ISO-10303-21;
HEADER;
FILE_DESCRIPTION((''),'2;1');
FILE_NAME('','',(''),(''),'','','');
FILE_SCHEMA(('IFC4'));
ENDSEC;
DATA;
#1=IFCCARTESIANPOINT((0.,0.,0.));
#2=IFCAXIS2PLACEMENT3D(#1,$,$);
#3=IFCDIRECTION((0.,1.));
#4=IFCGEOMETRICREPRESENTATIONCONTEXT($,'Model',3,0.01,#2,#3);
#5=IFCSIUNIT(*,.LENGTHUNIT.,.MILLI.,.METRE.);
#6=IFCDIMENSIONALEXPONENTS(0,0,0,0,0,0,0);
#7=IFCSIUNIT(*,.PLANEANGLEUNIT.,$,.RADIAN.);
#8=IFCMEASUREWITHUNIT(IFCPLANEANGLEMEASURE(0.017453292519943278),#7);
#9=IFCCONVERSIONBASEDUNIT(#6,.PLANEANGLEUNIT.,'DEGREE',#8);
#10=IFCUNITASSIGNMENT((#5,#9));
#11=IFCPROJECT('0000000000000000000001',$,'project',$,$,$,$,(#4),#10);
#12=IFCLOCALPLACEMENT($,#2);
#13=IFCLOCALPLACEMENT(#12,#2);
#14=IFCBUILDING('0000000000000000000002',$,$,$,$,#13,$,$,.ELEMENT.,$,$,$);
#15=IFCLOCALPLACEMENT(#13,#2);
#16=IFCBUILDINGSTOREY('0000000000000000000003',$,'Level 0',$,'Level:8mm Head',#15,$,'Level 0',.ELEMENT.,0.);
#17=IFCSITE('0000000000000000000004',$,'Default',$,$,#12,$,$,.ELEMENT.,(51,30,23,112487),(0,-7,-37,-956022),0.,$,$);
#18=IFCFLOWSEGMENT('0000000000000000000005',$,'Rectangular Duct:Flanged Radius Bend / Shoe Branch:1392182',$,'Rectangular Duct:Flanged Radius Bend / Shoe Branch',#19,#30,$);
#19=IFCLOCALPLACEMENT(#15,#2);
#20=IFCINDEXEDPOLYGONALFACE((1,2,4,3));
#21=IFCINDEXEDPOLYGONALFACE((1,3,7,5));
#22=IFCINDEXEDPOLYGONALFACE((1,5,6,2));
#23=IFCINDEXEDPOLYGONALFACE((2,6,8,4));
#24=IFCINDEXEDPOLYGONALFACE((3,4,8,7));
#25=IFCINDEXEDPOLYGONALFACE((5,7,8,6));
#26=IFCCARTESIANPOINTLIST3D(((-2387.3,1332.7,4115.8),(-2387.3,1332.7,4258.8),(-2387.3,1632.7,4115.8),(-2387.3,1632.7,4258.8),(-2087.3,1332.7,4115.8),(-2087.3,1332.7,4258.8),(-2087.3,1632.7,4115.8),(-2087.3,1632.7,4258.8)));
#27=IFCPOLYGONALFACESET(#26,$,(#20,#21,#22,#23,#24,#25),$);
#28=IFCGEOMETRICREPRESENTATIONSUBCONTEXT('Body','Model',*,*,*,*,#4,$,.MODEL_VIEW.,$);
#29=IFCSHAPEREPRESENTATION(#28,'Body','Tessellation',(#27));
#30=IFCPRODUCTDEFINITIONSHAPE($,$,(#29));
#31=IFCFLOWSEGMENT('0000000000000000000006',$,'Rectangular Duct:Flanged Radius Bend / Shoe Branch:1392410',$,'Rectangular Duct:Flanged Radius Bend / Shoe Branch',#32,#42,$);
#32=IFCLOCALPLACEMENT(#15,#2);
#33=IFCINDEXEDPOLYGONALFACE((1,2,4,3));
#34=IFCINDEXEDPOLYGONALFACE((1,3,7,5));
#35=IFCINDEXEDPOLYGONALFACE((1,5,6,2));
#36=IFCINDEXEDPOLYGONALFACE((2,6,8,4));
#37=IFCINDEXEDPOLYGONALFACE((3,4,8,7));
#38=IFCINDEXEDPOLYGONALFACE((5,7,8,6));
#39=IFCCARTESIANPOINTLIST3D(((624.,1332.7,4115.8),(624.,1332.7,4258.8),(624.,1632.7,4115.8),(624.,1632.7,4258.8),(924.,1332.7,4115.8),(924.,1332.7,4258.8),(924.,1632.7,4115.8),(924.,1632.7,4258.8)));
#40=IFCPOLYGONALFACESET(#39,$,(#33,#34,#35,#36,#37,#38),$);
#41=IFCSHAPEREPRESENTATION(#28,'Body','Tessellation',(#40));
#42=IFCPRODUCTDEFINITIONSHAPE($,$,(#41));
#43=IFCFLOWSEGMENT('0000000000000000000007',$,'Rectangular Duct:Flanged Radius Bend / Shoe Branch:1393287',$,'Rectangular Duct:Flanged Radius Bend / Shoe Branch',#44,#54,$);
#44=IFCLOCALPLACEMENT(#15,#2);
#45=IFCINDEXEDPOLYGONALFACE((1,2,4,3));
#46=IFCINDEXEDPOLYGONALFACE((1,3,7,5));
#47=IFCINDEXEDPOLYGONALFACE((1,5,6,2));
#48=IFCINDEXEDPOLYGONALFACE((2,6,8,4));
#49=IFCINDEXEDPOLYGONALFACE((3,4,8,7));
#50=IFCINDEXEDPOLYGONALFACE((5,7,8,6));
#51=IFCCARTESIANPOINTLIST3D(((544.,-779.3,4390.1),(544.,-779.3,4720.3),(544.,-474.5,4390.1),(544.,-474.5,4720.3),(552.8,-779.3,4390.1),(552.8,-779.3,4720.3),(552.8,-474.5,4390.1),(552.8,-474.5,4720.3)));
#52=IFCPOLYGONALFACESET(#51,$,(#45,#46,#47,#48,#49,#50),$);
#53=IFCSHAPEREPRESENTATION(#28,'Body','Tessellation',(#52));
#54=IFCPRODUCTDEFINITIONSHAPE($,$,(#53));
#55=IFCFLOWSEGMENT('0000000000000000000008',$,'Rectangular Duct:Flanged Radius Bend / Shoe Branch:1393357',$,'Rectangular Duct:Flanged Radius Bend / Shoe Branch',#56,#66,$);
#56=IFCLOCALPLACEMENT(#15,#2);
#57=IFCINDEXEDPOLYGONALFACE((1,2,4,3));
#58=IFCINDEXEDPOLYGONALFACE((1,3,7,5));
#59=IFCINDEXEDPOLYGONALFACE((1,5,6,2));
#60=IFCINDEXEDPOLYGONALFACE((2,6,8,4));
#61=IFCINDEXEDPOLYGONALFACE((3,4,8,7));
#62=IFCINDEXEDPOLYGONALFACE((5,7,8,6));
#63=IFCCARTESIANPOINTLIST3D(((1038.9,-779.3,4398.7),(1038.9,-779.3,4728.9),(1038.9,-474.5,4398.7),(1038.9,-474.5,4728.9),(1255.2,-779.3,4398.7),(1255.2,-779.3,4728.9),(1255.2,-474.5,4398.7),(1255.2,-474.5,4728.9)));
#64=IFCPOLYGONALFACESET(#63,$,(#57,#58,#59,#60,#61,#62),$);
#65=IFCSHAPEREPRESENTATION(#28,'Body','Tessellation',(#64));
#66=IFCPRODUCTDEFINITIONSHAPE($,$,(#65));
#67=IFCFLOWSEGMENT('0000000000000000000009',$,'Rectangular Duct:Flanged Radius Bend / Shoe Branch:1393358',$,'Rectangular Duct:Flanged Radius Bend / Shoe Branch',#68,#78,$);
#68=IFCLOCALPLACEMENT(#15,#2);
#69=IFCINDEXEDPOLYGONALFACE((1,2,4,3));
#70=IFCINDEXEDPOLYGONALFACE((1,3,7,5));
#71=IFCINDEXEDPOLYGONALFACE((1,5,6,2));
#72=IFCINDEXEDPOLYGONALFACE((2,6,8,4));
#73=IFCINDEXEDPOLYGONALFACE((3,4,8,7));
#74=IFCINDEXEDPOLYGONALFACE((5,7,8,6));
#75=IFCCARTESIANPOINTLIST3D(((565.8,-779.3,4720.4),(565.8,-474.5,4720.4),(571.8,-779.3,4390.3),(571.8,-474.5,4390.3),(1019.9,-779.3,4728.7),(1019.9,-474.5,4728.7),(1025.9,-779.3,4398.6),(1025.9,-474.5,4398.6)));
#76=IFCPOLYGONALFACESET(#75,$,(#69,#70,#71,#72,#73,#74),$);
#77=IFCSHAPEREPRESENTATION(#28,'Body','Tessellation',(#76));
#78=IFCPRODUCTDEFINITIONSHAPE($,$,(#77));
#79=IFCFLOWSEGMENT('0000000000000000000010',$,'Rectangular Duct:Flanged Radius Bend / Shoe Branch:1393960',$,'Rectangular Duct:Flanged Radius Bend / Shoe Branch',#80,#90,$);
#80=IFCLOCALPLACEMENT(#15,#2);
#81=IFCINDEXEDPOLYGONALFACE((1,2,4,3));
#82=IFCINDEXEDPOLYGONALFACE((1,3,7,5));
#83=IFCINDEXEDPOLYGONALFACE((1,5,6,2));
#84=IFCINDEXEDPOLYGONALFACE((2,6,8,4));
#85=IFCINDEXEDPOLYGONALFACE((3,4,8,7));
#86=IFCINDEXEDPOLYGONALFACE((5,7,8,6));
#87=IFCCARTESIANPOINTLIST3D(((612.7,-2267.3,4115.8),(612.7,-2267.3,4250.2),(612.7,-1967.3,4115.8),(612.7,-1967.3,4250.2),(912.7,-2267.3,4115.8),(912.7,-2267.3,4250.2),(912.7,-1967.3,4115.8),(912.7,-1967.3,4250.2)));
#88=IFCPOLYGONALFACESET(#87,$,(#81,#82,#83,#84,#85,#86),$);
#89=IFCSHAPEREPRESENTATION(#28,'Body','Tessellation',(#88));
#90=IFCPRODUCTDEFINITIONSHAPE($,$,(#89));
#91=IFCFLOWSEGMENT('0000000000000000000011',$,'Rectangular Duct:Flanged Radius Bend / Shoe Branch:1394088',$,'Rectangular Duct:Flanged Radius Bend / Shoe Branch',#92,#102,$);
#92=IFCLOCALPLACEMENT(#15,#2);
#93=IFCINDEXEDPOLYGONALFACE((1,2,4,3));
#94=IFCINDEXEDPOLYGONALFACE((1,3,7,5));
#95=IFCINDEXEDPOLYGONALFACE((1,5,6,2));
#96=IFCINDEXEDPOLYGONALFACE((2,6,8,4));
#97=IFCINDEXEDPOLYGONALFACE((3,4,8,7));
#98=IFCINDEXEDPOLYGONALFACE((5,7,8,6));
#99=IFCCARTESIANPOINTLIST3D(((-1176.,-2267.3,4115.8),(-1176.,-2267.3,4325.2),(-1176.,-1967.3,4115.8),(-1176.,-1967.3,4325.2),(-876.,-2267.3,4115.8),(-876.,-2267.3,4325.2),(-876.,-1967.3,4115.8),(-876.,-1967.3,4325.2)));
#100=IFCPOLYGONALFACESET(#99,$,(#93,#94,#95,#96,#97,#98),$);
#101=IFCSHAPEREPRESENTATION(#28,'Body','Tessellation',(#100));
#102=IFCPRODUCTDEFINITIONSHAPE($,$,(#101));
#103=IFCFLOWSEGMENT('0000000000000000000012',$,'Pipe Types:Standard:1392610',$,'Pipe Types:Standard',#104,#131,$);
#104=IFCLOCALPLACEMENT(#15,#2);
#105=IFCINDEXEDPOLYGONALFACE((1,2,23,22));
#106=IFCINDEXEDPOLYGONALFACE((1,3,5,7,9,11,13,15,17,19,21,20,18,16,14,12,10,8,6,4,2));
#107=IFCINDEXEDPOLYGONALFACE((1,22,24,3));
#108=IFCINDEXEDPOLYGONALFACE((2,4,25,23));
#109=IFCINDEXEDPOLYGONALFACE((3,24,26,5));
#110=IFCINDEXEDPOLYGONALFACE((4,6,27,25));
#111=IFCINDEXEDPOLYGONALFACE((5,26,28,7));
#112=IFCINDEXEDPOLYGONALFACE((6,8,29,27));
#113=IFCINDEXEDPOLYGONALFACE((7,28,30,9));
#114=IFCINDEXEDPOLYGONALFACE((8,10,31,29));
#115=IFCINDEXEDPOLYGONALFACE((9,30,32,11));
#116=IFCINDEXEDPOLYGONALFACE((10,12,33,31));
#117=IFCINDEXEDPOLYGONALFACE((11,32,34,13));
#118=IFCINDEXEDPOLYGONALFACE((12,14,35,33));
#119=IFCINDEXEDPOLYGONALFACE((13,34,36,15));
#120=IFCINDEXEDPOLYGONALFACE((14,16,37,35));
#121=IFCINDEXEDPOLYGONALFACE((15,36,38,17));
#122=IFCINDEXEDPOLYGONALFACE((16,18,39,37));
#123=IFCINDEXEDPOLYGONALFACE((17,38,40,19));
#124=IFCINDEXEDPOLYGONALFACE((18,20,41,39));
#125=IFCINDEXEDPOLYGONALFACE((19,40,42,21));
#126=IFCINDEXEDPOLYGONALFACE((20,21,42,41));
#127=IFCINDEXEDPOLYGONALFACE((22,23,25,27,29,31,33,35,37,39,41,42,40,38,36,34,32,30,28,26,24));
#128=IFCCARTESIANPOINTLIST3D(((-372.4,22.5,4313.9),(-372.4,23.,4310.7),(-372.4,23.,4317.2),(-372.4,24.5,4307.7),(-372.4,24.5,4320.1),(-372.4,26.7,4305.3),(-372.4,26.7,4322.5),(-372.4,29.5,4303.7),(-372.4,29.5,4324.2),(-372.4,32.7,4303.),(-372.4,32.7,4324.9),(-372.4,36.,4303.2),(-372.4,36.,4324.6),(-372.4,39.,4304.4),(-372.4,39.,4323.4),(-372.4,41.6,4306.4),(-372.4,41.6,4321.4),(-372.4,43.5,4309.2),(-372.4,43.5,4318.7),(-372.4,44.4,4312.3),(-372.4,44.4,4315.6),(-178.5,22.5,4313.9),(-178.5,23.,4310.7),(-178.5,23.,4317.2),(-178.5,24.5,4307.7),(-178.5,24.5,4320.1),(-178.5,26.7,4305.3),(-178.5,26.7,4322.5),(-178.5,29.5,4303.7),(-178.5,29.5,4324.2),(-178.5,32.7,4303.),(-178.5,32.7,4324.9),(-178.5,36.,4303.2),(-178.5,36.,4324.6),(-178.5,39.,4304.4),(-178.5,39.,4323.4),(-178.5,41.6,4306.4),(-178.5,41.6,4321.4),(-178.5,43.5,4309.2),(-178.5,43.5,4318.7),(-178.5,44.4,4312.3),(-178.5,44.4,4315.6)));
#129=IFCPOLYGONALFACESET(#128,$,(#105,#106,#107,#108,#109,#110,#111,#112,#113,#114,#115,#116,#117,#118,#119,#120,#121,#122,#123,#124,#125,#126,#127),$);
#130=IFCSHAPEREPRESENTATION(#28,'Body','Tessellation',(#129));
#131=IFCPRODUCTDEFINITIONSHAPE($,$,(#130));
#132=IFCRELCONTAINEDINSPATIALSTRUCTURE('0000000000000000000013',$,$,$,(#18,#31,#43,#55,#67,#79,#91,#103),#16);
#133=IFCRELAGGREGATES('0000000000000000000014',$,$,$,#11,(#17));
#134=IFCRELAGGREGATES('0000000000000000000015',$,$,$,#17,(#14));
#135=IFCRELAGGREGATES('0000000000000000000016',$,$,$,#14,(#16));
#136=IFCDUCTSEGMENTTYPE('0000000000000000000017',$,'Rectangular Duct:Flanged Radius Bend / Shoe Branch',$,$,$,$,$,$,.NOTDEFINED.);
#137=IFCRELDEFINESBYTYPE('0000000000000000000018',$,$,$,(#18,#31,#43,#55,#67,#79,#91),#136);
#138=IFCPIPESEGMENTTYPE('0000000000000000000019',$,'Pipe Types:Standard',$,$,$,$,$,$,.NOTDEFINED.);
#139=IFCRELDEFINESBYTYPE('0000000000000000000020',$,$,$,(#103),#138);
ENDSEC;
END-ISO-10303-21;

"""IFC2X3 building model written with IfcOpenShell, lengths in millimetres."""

from ifc_helpers import new_model, entity, si_unit, converted_unit, direction, frame, frame_2d, origin, origin_2d_with_axis, place, context, subcontext, project, spatial, rectangle, circle, extrude, type_object, element, save


model = new_model("IFC2X3")

# Units and contexts
model_context = context("Model", 3, precision=0.01, world=origin(), true_north=direction((0.0, 1.0)))
body_context = subcontext(model_context, "Body", "Model", "MODEL_VIEW")
ifc_project = project(units=[si_unit("LENGTHUNIT", "METRE", prefix="MILLI"), converted_unit("PLANEANGLEUNIT", "DEGREE", entity("IfcPlaneAngleMeasure", 0.017453292519943278), si_unit("PLANEANGLEUNIT", "RADIAN"), dimensions=[0, 0, 0, 0, 0, 0, 0])], contexts=[model_context])

# Site, building, storey
site_placement = place(None, origin())
site = spatial("IfcSite", under=ifc_project, at=site_placement, Name="Default", CompositionType="ELEMENT", RefLatitude=(51, 30, 23, 112487), RefLongitude=(0, -7, -37, -956022), RefElevation=0.0)
building_placement = place(site_placement, origin())
building = spatial("IfcBuilding", under=site, at=building_placement, CompositionType="ELEMENT")
storey_placement = place(building_placement, origin())
storey = spatial("IfcBuildingStorey", under=building, at=storey_placement, Name="Level 0", ObjectType="Level:8mm Head", LongName="Level 0", CompositionType="ELEMENT", Elevation=0.0)

# Flow segments
duct_segment_type = type_object("IfcDuctSegmentType", Name="Rectangular Duct:Flanged Radius Bend / Shoe Branch", PredefinedType="NOTDEFINED")
flow_segment_1_placement = place(storey_placement, origin())
element("IfcFlowSegment", 1, at=flow_segment_1_placement, inside=storey, type_object=duct_segment_type, Name="Rectangular Duct:Flanged Radius Bend / Shoe Branch:1392182", ObjectType="Rectangular Duct:Flanged Radius Bend / Shoe Branch", context=body_context, shape_type="SweptSolid", body=[
    extrude(rectangle(XDim=300.0, YDim=300.0, at=origin_2d_with_axis()), frame((-2237.3, 1482.7, 4115.8), z_axis=(0.0, 0.0, 1.0), x_axis=(-1.0, 0.0, 0.0)), (0.0, 0.0, 1.0), 143.0),
])
flow_segment_2_placement = place(storey_placement, origin())
element("IfcFlowSegment", 2, at=flow_segment_2_placement, inside=storey, type_object=duct_segment_type, Name="Rectangular Duct:Flanged Radius Bend / Shoe Branch:1392410", ObjectType="Rectangular Duct:Flanged Radius Bend / Shoe Branch", context=body_context, shape_type="SweptSolid", body=[
    extrude(rectangle(XDim=300.0, YDim=300.0, at=origin_2d_with_axis()), frame((774.0, 1482.7, 4115.8)), (0.0, 0.0, 1.0), 143.0),
])
flow_segment_3_placement = place(storey_placement, origin())
element("IfcFlowSegment", 3, at=flow_segment_3_placement, inside=storey, type_object=duct_segment_type, Name="Rectangular Duct:Flanged Radius Bend / Shoe Branch:1393287", ObjectType="Rectangular Duct:Flanged Radius Bend / Shoe Branch", context=body_context, shape_type="SweptSolid", body=[
    extrude(rectangle(XDim=8.8, YDim=304.8, at=origin_2d_with_axis()), frame((548.4, -626.9, 4390.1), z_axis=(0.0, 0.0, 1.0), x_axis=(-1.0, 0.0, 0.0)), (0.0, 0.0, 1.0), 330.2),
])
flow_segment_4_placement = place(storey_placement, origin())
element("IfcFlowSegment", 4, at=flow_segment_4_placement, inside=storey, type_object=duct_segment_type, Name="Rectangular Duct:Flanged Radius Bend / Shoe Branch:1393357", ObjectType="Rectangular Duct:Flanged Radius Bend / Shoe Branch", context=body_context, shape_type="SweptSolid", body=[
    extrude(rectangle(XDim=216.3, YDim=304.8, at=frame_2d((0.0, 0.0), x_axis=(1.0, 0.0))), frame((1147.1, -626.9, 4398.7), z_axis=(0.0, 0.0, 1.0), x_axis=(-1.0, 0.0, 0.0)), (0.0, 0.0, 1.0), 330.2),
])
flow_segment_5_placement = place(storey_placement, origin())
element("IfcFlowSegment", 5, at=flow_segment_5_placement, inside=storey, type_object=duct_segment_type, Name="Rectangular Duct:Flanged Radius Bend / Shoe Branch:1393358", ObjectType="Rectangular Duct:Flanged Radius Bend / Shoe Branch", context=body_context, shape_type="SweptSolid", body=[
    extrude(rectangle(XDim=330.2, YDim=304.8, at=frame_2d((0.0, 0.0), x_axis=(0.0, 1.0))), frame((568.8, -626.9, 4555.4), z_axis=(0.999833, 0.0, 0.018291), x_axis=(0.0, 1.0, 0.0)), (0.0, 0.0, 1.0), 454.1),
])
flow_segment_6_placement = place(storey_placement, origin())
element("IfcFlowSegment", 6, at=flow_segment_6_placement, inside=storey, type_object=duct_segment_type, Name="Rectangular Duct:Flanged Radius Bend / Shoe Branch:1393960", ObjectType="Rectangular Duct:Flanged Radius Bend / Shoe Branch", context=body_context, shape_type="SweptSolid", body=[
    extrude(rectangle(XDim=300.0, YDim=300.0, at=origin_2d_with_axis()), frame((762.7, -2117.3, 4115.8), z_axis=(0.0, 0.0, 1.0), x_axis=(0.0, 1.0, 0.0)), (0.0, 0.0, 1.0), 134.4),
])
flow_segment_7_placement = place(storey_placement, origin())
element("IfcFlowSegment", 7, at=flow_segment_7_placement, inside=storey, type_object=duct_segment_type, Name="Rectangular Duct:Flanged Radius Bend / Shoe Branch:1394088", ObjectType="Rectangular Duct:Flanged Radius Bend / Shoe Branch", context=body_context, shape_type="SweptSolid", body=[
    extrude(rectangle(XDim=300.0, YDim=300.0, at=origin_2d_with_axis()), frame((-1026.0, -2117.3, 4115.8)), (0.0, 0.0, 1.0), 209.4),
])

# Flow segment
pipe_segment_type = type_object("IfcPipeSegmentType", Name="Pipe Types:Standard", PredefinedType="NOTDEFINED")
flow_segment_8_placement = place(storey_placement, origin())
element("IfcFlowSegment", 8, at=flow_segment_8_placement, inside=storey, type_object=pipe_segment_type, Name="Pipe Types:Standard:1392610", ObjectType="Pipe Types:Standard", context=body_context, shape_type="SweptSolid", body=[
    extrude(circle(Radius=11.0, at=frame_2d((0.0, 0.0), x_axis=(1.0, 0.0))), frame((-372.4, 33.5, 4313.9), z_axis=(1.0, 0.0, 0.0), x_axis=(0.0, -1.0, 0.0)), (0.0, 0.0, 1.0), 193.9),
])

save(model, "model.ifc")
